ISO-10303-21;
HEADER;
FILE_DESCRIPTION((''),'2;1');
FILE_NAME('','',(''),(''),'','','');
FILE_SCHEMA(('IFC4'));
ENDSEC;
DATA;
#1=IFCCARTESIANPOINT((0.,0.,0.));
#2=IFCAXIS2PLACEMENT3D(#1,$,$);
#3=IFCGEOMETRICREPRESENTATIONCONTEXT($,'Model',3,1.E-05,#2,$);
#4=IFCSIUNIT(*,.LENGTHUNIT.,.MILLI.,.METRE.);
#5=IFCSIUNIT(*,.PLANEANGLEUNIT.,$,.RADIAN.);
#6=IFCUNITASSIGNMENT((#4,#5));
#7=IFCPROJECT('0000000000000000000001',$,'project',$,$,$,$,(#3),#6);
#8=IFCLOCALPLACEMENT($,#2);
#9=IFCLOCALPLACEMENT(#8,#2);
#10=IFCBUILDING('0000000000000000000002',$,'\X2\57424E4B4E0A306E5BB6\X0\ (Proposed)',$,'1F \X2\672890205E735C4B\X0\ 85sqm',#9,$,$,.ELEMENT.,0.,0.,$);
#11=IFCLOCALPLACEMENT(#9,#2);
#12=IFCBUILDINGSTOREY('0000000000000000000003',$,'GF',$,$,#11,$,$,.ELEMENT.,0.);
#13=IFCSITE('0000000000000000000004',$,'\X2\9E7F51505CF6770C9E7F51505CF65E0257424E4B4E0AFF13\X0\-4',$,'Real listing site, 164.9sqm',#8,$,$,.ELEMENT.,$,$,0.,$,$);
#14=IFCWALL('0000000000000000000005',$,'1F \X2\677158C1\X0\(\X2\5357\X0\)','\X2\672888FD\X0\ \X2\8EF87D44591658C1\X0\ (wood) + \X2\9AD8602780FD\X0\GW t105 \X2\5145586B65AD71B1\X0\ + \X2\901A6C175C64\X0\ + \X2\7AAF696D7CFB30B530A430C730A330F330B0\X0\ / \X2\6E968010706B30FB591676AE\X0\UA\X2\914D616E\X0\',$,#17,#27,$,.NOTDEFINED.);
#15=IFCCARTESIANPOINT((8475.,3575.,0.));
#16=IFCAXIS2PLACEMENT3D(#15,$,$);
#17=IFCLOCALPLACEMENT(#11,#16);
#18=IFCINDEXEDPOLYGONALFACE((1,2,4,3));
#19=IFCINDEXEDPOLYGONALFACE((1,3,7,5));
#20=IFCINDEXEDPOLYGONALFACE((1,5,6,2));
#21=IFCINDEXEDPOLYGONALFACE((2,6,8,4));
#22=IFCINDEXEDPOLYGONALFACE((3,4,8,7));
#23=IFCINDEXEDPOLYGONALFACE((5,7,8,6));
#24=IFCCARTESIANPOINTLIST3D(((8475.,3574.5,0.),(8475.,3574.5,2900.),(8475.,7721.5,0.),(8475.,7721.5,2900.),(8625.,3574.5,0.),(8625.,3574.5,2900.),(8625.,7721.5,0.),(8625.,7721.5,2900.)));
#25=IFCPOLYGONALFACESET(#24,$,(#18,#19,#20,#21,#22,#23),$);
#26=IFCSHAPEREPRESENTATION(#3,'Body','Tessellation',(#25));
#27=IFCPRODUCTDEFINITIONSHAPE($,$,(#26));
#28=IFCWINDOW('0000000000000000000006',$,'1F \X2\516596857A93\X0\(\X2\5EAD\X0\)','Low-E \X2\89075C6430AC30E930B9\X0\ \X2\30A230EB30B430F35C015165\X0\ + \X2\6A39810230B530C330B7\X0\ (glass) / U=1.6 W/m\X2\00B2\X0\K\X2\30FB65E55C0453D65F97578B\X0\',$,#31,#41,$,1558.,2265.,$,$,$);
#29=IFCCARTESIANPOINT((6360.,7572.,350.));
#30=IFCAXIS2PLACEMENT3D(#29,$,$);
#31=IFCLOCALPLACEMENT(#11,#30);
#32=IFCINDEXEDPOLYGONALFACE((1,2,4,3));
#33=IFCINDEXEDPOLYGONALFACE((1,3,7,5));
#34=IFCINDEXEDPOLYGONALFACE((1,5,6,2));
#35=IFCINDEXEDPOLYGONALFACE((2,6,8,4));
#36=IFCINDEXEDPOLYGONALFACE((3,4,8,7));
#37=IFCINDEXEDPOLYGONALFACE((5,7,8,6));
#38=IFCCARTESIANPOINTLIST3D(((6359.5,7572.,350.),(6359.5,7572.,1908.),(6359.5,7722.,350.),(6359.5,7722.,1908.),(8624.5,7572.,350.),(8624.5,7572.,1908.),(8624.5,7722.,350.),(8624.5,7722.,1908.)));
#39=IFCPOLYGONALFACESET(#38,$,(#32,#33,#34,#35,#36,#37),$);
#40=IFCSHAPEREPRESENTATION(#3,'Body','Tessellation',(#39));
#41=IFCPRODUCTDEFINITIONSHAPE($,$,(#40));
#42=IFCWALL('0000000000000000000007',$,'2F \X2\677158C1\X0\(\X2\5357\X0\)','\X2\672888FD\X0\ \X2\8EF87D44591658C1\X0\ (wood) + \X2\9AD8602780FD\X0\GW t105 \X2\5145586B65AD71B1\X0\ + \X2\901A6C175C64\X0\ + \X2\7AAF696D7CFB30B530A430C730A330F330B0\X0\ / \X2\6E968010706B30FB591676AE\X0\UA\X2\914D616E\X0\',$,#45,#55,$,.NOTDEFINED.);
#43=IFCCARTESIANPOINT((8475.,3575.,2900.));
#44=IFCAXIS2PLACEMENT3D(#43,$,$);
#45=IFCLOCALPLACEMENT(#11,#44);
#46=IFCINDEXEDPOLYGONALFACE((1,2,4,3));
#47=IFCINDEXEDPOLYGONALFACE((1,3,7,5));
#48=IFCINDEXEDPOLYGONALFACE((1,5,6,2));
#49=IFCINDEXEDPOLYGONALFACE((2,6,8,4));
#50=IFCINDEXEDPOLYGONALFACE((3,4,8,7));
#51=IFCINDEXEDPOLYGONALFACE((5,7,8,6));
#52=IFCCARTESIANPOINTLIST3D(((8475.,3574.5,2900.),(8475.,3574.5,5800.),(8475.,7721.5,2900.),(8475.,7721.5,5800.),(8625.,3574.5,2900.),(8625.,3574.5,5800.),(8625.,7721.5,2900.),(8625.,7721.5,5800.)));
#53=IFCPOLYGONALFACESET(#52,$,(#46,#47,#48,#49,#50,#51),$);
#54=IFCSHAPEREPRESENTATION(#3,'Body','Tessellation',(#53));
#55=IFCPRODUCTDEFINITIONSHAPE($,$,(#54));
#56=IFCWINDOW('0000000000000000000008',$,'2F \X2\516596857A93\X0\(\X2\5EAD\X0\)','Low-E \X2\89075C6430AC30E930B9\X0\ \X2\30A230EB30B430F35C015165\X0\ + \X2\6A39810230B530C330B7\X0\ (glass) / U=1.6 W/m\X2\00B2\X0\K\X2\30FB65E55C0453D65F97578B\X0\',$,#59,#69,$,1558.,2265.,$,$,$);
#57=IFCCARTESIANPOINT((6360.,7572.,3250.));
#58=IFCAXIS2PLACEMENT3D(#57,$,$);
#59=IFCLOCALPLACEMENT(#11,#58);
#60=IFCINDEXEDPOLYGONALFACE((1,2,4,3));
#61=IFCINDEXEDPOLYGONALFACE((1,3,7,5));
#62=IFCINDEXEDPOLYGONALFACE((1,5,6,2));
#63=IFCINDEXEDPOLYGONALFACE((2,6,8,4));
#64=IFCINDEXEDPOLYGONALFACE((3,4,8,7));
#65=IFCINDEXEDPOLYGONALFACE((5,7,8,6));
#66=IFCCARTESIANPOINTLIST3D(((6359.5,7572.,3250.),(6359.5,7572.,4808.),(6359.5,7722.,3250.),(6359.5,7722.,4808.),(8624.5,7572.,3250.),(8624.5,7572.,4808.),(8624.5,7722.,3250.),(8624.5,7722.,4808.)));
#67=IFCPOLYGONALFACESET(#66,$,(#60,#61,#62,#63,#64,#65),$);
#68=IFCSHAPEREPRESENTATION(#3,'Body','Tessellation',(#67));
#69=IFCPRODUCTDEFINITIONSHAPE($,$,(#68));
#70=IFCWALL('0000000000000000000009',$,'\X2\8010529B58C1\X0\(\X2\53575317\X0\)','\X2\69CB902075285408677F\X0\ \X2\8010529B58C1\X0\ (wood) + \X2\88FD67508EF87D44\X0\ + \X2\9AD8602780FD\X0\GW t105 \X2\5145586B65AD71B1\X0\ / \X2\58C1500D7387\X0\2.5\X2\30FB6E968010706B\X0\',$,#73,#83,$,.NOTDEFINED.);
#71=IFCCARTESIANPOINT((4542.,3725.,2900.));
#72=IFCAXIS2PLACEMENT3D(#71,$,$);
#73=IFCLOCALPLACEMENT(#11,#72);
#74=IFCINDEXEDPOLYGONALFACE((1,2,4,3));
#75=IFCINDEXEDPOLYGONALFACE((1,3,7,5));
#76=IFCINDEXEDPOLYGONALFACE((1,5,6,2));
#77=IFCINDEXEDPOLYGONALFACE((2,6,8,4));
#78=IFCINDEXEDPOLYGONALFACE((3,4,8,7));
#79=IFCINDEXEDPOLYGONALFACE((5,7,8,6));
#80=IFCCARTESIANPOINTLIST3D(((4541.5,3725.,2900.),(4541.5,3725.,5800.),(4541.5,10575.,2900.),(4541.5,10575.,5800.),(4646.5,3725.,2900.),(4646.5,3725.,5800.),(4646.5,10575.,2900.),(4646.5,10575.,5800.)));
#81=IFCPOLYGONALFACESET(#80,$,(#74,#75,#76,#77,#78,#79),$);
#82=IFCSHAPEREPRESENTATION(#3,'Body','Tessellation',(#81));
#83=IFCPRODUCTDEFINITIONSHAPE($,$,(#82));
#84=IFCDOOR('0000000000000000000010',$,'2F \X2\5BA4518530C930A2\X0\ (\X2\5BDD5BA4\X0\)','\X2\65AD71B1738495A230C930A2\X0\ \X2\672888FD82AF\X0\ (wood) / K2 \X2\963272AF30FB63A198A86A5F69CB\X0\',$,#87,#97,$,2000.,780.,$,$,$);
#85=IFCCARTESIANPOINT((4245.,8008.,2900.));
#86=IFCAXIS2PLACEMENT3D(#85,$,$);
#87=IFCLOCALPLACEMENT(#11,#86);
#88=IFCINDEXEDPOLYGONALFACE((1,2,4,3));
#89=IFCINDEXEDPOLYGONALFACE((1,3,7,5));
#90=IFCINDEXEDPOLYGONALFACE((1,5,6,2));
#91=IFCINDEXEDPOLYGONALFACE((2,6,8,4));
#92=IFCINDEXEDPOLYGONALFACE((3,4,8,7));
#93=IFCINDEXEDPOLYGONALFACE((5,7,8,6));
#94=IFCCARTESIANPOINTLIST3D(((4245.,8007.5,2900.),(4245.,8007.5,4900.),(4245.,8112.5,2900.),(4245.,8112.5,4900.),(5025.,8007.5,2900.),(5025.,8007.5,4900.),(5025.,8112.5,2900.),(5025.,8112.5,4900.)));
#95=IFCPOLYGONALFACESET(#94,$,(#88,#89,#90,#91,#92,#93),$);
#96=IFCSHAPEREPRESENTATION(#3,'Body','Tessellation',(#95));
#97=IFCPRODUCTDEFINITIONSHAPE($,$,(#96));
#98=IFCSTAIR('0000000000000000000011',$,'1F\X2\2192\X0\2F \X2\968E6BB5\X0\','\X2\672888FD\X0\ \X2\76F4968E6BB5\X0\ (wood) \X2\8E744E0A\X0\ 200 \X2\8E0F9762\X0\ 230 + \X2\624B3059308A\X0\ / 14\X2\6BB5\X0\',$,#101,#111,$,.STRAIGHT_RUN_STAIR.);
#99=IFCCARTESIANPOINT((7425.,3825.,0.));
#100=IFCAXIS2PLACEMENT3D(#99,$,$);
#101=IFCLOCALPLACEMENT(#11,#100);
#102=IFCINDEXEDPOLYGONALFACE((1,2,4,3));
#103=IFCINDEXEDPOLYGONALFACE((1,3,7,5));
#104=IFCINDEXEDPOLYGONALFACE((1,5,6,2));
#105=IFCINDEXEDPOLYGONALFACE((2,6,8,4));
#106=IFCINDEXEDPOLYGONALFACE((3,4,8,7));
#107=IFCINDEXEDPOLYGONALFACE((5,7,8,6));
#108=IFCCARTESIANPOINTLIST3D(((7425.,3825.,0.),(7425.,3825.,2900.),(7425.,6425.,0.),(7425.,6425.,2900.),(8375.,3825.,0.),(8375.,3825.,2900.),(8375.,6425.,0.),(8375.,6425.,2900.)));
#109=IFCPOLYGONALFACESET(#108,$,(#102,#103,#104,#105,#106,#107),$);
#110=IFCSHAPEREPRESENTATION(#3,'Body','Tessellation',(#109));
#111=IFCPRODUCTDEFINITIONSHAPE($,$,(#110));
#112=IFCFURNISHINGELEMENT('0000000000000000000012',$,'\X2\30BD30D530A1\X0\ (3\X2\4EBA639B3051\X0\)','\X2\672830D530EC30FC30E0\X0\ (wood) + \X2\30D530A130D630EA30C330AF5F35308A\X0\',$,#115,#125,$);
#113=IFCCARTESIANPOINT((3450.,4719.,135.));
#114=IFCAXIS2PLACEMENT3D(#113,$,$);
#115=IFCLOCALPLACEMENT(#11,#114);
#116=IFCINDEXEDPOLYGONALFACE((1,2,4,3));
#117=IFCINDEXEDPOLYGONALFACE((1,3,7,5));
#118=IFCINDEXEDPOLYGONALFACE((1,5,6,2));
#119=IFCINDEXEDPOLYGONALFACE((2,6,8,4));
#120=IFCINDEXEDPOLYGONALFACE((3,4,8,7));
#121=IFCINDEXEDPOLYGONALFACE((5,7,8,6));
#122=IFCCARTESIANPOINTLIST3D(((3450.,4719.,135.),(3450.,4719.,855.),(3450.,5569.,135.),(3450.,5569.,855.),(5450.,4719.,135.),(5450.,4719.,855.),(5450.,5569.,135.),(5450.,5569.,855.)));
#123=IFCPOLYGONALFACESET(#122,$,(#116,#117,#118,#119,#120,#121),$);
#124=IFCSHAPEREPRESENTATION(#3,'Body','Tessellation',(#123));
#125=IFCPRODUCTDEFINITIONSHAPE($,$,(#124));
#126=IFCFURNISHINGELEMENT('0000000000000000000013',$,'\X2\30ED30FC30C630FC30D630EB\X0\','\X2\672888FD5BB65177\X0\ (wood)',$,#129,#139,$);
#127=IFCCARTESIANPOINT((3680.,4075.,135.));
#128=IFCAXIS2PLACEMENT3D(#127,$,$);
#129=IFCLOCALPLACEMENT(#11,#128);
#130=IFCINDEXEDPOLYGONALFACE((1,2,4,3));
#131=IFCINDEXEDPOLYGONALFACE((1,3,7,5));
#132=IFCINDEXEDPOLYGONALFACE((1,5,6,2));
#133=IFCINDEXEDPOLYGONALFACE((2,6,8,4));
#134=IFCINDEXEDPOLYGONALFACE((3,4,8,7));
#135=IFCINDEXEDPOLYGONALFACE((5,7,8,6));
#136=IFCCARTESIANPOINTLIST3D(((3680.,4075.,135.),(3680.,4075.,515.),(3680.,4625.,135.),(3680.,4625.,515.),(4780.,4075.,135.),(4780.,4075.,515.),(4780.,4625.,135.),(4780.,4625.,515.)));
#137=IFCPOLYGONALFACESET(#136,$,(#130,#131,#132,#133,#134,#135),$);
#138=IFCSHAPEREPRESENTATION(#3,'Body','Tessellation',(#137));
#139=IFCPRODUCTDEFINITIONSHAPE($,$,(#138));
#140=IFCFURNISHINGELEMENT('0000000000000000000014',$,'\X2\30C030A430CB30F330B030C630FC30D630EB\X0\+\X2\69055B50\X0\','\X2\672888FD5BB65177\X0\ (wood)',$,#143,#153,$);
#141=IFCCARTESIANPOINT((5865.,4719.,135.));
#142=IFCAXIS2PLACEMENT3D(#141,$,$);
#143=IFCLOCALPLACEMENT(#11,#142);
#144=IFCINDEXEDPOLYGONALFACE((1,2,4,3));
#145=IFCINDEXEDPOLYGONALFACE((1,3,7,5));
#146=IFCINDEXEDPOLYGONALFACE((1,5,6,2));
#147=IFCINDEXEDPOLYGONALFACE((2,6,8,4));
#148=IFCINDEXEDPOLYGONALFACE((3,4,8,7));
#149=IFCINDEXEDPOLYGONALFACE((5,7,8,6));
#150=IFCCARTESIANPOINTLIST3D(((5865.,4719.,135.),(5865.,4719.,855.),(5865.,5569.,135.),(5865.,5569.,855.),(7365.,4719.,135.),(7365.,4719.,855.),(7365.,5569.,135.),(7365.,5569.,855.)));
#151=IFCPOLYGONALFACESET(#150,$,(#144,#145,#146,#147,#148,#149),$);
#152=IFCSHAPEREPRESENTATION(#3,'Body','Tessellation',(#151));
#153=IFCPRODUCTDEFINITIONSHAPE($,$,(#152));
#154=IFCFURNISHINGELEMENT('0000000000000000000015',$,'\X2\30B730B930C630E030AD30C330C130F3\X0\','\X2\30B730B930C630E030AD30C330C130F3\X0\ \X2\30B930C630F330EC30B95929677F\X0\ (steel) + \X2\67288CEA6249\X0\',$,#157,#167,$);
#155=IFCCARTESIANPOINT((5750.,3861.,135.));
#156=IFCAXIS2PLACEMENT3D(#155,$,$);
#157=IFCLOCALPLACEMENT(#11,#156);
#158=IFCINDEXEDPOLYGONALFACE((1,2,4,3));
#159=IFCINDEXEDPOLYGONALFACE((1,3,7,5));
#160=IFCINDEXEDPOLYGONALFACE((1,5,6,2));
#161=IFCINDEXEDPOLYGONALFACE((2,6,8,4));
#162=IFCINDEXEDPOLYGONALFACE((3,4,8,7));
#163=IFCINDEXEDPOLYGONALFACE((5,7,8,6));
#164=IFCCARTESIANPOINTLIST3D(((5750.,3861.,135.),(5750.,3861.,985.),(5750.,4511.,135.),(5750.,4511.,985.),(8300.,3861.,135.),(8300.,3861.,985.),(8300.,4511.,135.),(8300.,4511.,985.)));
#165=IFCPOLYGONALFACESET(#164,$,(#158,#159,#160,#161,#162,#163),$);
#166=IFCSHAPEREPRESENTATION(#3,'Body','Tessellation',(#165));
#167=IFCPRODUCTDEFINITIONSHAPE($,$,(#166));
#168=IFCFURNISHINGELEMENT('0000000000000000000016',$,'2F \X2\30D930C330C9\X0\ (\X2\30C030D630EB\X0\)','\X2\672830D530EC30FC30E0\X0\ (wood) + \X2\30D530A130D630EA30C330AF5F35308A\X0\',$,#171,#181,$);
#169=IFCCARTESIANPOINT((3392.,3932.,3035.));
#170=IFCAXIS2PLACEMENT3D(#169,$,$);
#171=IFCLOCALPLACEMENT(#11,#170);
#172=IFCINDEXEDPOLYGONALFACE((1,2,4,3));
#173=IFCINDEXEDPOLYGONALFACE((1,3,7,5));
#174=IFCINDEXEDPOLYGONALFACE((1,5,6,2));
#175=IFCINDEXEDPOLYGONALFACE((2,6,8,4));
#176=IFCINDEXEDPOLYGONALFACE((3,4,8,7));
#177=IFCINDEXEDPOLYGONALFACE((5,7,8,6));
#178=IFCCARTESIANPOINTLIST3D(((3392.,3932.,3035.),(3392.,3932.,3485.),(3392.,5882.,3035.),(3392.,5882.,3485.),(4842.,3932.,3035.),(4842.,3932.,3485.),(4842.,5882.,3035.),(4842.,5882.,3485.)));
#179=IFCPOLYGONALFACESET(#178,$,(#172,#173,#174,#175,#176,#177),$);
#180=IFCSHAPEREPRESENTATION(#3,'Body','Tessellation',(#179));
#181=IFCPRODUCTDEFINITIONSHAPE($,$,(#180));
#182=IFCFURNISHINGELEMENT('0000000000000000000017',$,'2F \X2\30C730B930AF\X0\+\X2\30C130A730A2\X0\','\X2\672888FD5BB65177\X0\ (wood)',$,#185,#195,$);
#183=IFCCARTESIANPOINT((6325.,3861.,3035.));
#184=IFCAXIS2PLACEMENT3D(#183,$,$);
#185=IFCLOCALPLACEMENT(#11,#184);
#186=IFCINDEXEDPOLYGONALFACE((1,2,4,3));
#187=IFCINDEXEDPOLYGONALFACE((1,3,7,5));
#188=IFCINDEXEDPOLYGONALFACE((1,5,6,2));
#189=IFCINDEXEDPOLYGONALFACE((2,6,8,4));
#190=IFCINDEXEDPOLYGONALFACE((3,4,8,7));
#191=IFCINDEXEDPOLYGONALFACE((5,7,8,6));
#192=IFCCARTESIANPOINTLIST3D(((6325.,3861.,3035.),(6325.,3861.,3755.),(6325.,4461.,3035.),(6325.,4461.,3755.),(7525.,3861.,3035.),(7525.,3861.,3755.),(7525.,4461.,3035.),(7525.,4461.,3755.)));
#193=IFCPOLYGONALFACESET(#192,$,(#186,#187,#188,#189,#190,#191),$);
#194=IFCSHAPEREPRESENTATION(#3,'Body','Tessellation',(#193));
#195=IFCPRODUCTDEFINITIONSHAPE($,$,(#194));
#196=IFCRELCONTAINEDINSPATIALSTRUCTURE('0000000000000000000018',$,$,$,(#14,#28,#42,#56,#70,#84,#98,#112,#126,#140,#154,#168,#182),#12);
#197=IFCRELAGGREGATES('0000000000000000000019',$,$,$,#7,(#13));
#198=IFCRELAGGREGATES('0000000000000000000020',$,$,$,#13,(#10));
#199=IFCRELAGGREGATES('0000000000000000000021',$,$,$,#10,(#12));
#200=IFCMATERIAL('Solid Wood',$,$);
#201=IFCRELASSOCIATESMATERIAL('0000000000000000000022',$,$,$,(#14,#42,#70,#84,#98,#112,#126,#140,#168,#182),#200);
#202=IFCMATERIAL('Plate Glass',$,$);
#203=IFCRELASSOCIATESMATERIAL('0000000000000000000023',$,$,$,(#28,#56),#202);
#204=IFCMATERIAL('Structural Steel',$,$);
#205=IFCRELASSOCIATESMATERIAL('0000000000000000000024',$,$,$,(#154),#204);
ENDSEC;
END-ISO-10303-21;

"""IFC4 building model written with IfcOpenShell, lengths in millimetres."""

from ifc_helpers import new_model, si_unit, frame, frame_2d, origin, place, context, project, spatial, rectangle, extrude, material, element, fill, save


model = new_model("IFC4")

# Units and contexts
model_context = context("Model", 3, precision=1e-05, world=origin())
ifc_project = project(units=[si_unit("LENGTHUNIT", "METRE", prefix="MILLI"), si_unit("PLANEANGLEUNIT", "RADIAN")], contexts=[model_context])

# Site, building, storey
site_placement = place(None, origin())
site = spatial("IfcSite", under=ifc_project, at=site_placement, Name="鹿児島県鹿児島市坂之上３-4", ObjectType="Real listing site, 164.9sqm", CompositionType="ELEMENT", RefElevation=0.0)
building_placement = place(site_placement, origin())
building = spatial("IfcBuilding", under=site, at=building_placement, Name="坂之上の家 (Proposed)", ObjectType="1F 木造平屋 85sqm", CompositionType="ELEMENT", ElevationOfRefHeight=0.0, ElevationOfTerrain=0.0)
storey_placement = place(building_placement, origin())
storey = spatial("IfcBuildingStorey", under=building, at=storey_placement, Name="GF", CompositionType="ELEMENT", Elevation=0.0)

# Wall, opening, window
ifc_material_1 = material(Name="Solid Wood")
wall_1_placement = place(storey_placement, frame((8475.0, 3575.0, 0.0)))
wall_1 = element("IfcWall", 1, at=wall_1_placement, inside=storey, material=ifc_material_1, Name="1F 東壁(南)", Description="木製 軸組外壁 (wood) + 高性能GW t105 充填断熱 + 通気層 + 窯業系サイディング / 準耐火・外皮UA配慮", PredefinedType="NOTDEFINED", context=model_context, shape_type="SweptSolid", body=[
    extrude(rectangle(XDim=150.0, YDim=4147.0, at=frame_2d((75.0, 2073.0))), frame((8475.0, 3575.0, 0.0)), (0.0, 0.0, 1.0), 2900.0),
])
opening_1_placement = place(storey_placement, frame((6360.0, 7572.0, 350.0)))
opening_1 = element("IfcOpeningElement", 2, at=opening_1_placement, cuts=wall_1, PredefinedType="NOTDEFINED", context=model_context, shape_type="SweptSolid", body=[
    extrude(rectangle(XDim=2265.0, YDim=150.0, at=frame_2d((1132.0, 75.0))), frame((6360.0, 7572.0, 350.0)), (0.0, 0.0, 1.0), 1558.0),
])
ifc_material_2 = material(Name="Plate Glass")
window_1_placement = place(storey_placement, frame((6360.0, 7572.0, 350.0)))
window_1 = element("IfcWindow", 3, at=window_1_placement, inside=storey, material=ifc_material_2, Name="1F 入隅窓(庭)", Description="Low-E 複層ガラス アルゴン封入 + 樹脂サッシ (glass) / U=1.6 W/m²K・日射取得型", OverallHeight=1558.0, OverallWidth=2265.0, context=model_context, shape_type="SweptSolid", body=[
    extrude(rectangle(XDim=2265.0, YDim=150.0, at=frame_2d((1132.0, 75.0))), frame((6360.0, 7572.0, 350.0)), (0.0, 0.0, 1.0), 1558.0),
])
fill(opening_1, window_1)

# Wall, opening, window
wall_2_placement = place(storey_placement, frame((8475.0, 3575.0, 2900.0)))
wall_2 = element("IfcWall", 4, at=wall_2_placement, inside=storey, material=ifc_material_1, Name="2F 東壁(南)", Description="木製 軸組外壁 (wood) + 高性能GW t105 充填断熱 + 通気層 + 窯業系サイディング / 準耐火・外皮UA配慮", PredefinedType="NOTDEFINED", context=model_context, shape_type="SweptSolid", body=[
    extrude(rectangle(XDim=150.0, YDim=4147.0, at=frame_2d((75.0, 2073.0))), frame((8475.0, 3575.0, 2900.0)), (0.0, 0.0, 1.0), 2900.0),
])
opening_2_placement = place(storey_placement, frame((6360.0, 7572.0, 3250.0)))
opening_2 = element("IfcOpeningElement", 5, at=opening_2_placement, cuts=wall_2, PredefinedType="NOTDEFINED", context=model_context, shape_type="SweptSolid", body=[
    extrude(rectangle(XDim=2265.0, YDim=150.0, at=frame_2d((1132.0, 75.0))), frame((6360.0, 7572.0, 3250.0)), (0.0, 0.0, 1.0), 1558.0),
])
window_2_placement = place(storey_placement, frame((6360.0, 7572.0, 3250.0)))
window_2 = element("IfcWindow", 6, at=window_2_placement, inside=storey, material=ifc_material_2, Name="2F 入隅窓(庭)", Description="Low-E 複層ガラス アルゴン封入 + 樹脂サッシ (glass) / U=1.6 W/m²K・日射取得型", OverallHeight=1558.0, OverallWidth=2265.0, context=model_context, shape_type="SweptSolid", body=[
    extrude(rectangle(XDim=2265.0, YDim=150.0, at=frame_2d((1132.0, 75.0))), frame((6360.0, 7572.0, 3250.0)), (0.0, 0.0, 1.0), 1558.0),
])
fill(opening_2, window_2)

# Wall, opening, door
wall_3_placement = place(storey_placement, frame((4542.0, 3725.0, 2900.0)))
wall_3 = element("IfcWall", 7, at=wall_3_placement, inside=storey, material=ifc_material_1, Name="耐力壁(南北)", Description="構造用合板 耐力壁 (wood) + 製材軸組 + 高性能GW t105 充填断熱 / 壁倍率2.5・準耐火", PredefinedType="NOTDEFINED", context=model_context, shape_type="SweptSolid", body=[
    extrude(rectangle(XDim=105.0, YDim=6850.0, at=frame_2d((52.0, 3425.0))), frame((4542.0, 3725.0, 2900.0)), (0.0, 0.0, 1.0), 2900.0),
])
opening_3_placement = place(storey_placement, frame((4245.0, 8008.0, 2900.0)))
opening_3 = element("IfcOpeningElement", 8, at=opening_3_placement, cuts=wall_3, PredefinedType="NOTDEFINED", context=model_context, shape_type="SweptSolid", body=[
    extrude(rectangle(XDim=780.0, YDim=105.0, at=frame_2d((390.0, 52.0))), frame((4245.0, 8008.0, 2900.0)), (0.0, 0.0, 1.0), 2000.0),
])
door_1_placement = place(storey_placement, frame((4245.0, 8008.0, 2900.0)))
door_1 = element("IfcDoor", 9, at=door_1_placement, inside=storey, material=ifc_material_1, Name="2F 室内ドア (寝室)", Description="断熱玄関ドア 木製芯 (wood) / K2 防犯・採風機構", OverallHeight=2000.0, OverallWidth=780.0, context=model_context, shape_type="SweptSolid", body=[
    extrude(rectangle(XDim=780.0, YDim=105.0, at=frame_2d((390.0, 52.0))), frame((4245.0, 8008.0, 2900.0)), (0.0, 0.0, 1.0), 2000.0),
])
fill(opening_3, door_1)

# Stair
stair_placement = place(storey_placement, frame((7425.0, 3825.0, 0.0)))
element("IfcStair", 10, at=stair_placement, inside=storey, material=ifc_material_1, Name="1F→2F 階段", Description="木製 直階段 (wood) 蹴上 200 踏面 230 + 手すり / 14段", PredefinedType="STRAIGHT_RUN_STAIR", context=model_context, shape_type="SweptSolid", body=[
    extrude(rectangle(XDim=950.0, YDim=2600.0, at=frame_2d((475.0, 1300.0))), frame((7425.0, 3825.0, 0.0)), (0.0, 0.0, 1.0), 2900.0),
])

# Furnishing elements
furnishing_1_placement = place(storey_placement, frame((3450.0, 4719.0, 135.0)))
element("IfcFurnishingElement", 11, at=furnishing_1_placement, inside=storey, material=ifc_material_1, Name="ソファ (3人掛け)", Description="木フレーム (wood) + ファブリック張り", context=model_context, shape_type="SweptSolid", body=[
    extrude(rectangle(XDim=2000.0, YDim=850.0, at=frame_2d((1000.0, 425.0))), frame((3450.0, 4719.0, 135.0)), (0.0, 0.0, 1.0), 720.0),
])
furnishing_2_placement = place(storey_placement, frame((3680.0, 4075.0, 135.0)))
element("IfcFurnishingElement", 12, at=furnishing_2_placement, inside=storey, material=ifc_material_1, Name="ローテーブル", Description="木製家具 (wood)", context=model_context, shape_type="SweptSolid", body=[
    extrude(rectangle(XDim=1100.0, YDim=550.0, at=frame_2d((550.0, 275.0))), frame((3680.0, 4075.0, 135.0)), (0.0, 0.0, 1.0), 380.0),
])
furnishing_3_placement = place(storey_placement, frame((5865.0, 4719.0, 135.0)))
element("IfcFurnishingElement", 13, at=furnishing_3_placement, inside=storey, material=ifc_material_1, Name="ダイニングテーブル+椅子", Description="木製家具 (wood)", context=model_context, shape_type="SweptSolid", body=[
    extrude(rectangle(XDim=1500.0, YDim=850.0, at=frame_2d((750.0, 425.0))), frame((5865.0, 4719.0, 135.0)), (0.0, 0.0, 1.0), 720.0),
])
ifc_material_3 = material(Name="Structural Steel")
furnishing_4_placement = place(storey_placement, frame((5750.0, 3861.0, 135.0)))
element("IfcFurnishingElement", 14, at=furnishing_4_placement, inside=storey, material=ifc_material_3, Name="システムキッチン", Description="システムキッチン ステンレス天板 (steel) + 木質扉", context=model_context, shape_type="SweptSolid", body=[
    extrude(rectangle(XDim=2550.0, YDim=650.0, at=frame_2d((1275.0, 325.0))), frame((5750.0, 3861.0, 135.0)), (0.0, 0.0, 1.0), 850.0),
])
furnishing_5_placement = place(storey_placement, frame((3392.0, 3932.0, 3035.0)))
element("IfcFurnishingElement", 15, at=furnishing_5_placement, inside=storey, material=ifc_material_1, Name="2F ベッド (ダブル)", Description="木フレーム (wood) + ファブリック張り", context=model_context, shape_type="SweptSolid", body=[
    extrude(rectangle(XDim=1450.0, YDim=1950.0, at=frame_2d((725.0, 975.0))), frame((3392.0, 3932.0, 3035.0)), (0.0, 0.0, 1.0), 450.0),
])
furnishing_6_placement = place(storey_placement, frame((6325.0, 3861.0, 3035.0)))
element("IfcFurnishingElement", 16, at=furnishing_6_placement, inside=storey, material=ifc_material_1, Name="2F デスク+チェア", Description="木製家具 (wood)", context=model_context, shape_type="SweptSolid", body=[
    extrude(rectangle(XDim=1200.0, YDim=600.0, at=frame_2d((600.0, 300.0))), frame((6325.0, 3861.0, 3035.0)), (0.0, 0.0, 1.0), 720.0),
])

save(model, "model.ifc")
